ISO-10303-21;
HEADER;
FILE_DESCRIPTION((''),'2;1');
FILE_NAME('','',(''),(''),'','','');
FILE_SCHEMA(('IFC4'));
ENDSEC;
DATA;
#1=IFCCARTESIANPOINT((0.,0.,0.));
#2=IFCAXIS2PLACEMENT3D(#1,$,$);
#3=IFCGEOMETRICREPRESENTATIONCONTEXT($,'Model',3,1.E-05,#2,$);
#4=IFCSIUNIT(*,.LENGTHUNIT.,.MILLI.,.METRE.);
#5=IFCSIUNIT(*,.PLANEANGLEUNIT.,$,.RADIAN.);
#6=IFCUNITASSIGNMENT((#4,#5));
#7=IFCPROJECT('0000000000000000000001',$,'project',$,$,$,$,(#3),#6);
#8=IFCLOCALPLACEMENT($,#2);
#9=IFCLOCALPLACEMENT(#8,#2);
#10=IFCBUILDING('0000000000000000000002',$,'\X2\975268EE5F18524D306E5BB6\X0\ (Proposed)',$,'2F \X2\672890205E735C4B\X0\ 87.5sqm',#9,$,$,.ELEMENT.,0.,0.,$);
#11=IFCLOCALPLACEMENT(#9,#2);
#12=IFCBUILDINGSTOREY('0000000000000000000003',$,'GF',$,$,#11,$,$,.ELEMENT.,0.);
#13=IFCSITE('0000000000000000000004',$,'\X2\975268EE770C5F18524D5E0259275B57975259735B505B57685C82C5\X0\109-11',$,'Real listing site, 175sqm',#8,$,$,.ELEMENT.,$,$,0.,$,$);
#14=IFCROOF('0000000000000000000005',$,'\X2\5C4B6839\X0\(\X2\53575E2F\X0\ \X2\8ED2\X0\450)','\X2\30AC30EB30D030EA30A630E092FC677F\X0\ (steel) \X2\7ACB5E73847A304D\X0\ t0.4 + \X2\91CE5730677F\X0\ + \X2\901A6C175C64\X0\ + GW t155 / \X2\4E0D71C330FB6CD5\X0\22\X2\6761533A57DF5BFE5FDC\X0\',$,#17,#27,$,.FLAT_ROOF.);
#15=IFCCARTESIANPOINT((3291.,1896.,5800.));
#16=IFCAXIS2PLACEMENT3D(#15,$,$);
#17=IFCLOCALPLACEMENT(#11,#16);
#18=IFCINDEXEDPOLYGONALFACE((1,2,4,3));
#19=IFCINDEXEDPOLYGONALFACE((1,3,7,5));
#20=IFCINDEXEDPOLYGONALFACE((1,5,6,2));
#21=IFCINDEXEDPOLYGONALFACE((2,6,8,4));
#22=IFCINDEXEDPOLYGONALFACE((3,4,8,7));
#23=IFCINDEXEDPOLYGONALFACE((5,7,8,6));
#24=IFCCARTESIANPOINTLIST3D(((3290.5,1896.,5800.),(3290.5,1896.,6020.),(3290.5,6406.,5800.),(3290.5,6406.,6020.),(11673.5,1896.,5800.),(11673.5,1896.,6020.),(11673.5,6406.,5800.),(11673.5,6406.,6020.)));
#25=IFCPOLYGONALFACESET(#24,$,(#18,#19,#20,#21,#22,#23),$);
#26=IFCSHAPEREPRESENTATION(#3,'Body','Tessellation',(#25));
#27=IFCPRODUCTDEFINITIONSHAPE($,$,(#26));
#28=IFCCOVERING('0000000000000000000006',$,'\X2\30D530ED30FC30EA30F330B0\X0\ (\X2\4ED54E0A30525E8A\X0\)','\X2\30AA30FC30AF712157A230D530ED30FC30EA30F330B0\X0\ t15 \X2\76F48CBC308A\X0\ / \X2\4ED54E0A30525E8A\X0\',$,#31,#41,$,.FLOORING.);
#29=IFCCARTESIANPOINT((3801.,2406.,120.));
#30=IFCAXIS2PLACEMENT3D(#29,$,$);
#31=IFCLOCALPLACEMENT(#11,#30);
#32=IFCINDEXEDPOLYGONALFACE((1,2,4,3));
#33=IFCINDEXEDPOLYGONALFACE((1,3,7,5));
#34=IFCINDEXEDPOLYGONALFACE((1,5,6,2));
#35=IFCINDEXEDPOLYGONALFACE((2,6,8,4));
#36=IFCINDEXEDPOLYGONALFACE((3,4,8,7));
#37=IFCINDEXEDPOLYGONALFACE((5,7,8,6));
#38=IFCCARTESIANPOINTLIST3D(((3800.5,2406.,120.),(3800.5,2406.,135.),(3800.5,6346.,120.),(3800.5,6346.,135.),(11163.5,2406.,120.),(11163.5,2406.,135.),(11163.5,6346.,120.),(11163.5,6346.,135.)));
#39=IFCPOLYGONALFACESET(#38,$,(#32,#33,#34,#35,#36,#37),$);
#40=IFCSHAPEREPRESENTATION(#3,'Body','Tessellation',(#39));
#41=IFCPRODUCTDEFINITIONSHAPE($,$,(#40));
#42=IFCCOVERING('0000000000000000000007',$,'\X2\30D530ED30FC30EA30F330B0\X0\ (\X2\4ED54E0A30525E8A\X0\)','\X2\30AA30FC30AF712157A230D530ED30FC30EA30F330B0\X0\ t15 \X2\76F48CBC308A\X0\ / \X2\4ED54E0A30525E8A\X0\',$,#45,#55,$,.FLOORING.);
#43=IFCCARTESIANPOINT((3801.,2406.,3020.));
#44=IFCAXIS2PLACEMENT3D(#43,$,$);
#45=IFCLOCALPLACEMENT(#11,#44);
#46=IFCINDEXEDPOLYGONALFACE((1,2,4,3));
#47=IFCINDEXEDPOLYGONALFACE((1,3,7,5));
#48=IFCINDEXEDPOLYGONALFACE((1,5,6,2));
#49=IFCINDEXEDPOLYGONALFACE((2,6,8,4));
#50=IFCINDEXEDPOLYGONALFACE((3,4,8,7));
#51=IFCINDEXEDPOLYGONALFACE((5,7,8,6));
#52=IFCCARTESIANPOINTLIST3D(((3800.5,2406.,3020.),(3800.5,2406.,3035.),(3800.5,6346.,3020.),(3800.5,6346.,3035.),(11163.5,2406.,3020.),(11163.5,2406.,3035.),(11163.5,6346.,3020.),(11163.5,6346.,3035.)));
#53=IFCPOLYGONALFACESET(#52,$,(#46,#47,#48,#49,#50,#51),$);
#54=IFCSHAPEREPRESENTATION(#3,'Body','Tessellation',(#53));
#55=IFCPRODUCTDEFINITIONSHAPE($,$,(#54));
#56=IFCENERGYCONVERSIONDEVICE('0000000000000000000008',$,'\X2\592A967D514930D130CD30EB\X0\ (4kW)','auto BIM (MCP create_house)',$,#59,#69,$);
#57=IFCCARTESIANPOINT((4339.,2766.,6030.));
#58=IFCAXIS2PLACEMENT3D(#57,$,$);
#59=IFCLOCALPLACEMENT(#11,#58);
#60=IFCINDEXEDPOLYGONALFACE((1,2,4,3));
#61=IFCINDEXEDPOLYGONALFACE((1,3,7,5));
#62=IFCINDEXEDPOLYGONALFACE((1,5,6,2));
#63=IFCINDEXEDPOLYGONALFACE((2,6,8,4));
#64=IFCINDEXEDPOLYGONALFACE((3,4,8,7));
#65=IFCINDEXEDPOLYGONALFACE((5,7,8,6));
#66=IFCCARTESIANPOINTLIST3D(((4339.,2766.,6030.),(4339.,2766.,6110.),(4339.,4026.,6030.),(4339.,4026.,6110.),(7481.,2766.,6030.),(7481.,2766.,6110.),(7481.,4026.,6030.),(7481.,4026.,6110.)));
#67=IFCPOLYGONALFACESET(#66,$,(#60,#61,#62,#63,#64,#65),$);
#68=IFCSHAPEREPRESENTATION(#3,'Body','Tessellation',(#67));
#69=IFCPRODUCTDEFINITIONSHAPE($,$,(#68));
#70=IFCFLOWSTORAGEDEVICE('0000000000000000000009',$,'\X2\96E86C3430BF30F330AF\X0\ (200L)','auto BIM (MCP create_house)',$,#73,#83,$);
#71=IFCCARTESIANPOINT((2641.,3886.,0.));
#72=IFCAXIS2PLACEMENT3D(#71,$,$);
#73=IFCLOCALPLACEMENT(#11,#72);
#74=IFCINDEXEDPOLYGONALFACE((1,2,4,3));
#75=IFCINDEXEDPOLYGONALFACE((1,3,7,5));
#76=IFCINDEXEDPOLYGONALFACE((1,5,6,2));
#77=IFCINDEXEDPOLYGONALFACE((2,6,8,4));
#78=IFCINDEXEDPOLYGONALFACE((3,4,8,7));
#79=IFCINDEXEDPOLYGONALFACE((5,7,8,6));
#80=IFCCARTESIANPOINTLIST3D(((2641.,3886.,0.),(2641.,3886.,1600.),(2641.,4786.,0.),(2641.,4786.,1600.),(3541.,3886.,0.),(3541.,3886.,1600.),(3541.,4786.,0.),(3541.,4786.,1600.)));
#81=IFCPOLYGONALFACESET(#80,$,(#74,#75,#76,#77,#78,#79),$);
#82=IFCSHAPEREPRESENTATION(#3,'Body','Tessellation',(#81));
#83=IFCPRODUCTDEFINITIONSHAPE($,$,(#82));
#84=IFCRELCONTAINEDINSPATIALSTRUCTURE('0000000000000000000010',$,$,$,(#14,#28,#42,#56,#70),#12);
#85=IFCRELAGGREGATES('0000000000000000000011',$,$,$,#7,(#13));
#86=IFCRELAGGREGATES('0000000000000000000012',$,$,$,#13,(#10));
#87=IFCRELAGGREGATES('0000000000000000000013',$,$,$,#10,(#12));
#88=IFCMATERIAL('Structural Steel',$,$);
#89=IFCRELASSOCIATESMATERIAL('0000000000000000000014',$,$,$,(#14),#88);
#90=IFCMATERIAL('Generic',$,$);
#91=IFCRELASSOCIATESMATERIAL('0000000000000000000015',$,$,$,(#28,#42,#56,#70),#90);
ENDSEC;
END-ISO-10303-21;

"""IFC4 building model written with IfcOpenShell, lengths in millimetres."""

from ifc_helpers import new_model, si_unit, frame, frame_2d, origin, place, context, project, spatial, rectangle, extrude, material, element, save


model = new_model("IFC4")

# Units and contexts
model_context = context("Model", 3, precision=1e-05, world=origin())
ifc_project = project(units=[si_unit("LENGTHUNIT", "METRE", prefix="MILLI"), si_unit("PLANEANGLEUNIT", "RADIAN")], contexts=[model_context])

# Site, building, storey
site_placement = place(None, origin())
site = spatial("IfcSite", under=ifc_project, at=site_placement, Name="青森県弘前市大字青女子字桜苅109-11", ObjectType="Real listing site, 175sqm", CompositionType="ELEMENT", RefElevation=0.0)
building_placement = place(site_placement, origin())
building = spatial("IfcBuilding", under=site, at=building_placement, Name="青森弘前の家 (Proposed)", ObjectType="2F 木造平屋 87.5sqm", CompositionType="ELEMENT", ElevationOfRefHeight=0.0, ElevationOfTerrain=0.0)
storey_placement = place(building_placement, origin())
storey = spatial("IfcBuildingStorey", under=building, at=storey_placement, Name="GF", CompositionType="ELEMENT", Elevation=0.0)

# Roof
ifc_material_1 = material(Name="Structural Steel")
for number, where, name in (
    (1, (3291.0, 1896.0, 5800.0), "屋根(南帯 軒450)"),
):
    element("IfcRoof", number, at=place(storey_placement, frame(where)), inside=storey, material=ifc_material_1, Name=name, Description="ガルバリウム鋼板 (steel) 立平葺き t0.4 + 野地板 + 通気層 + GW t155 / 不燃・法22条区域対応", PredefinedType="FLAT_ROOF", context=model_context, shape_type="SweptSolid", body=[
        extrude(rectangle(XDim=8383.0, YDim=4510.0, at=frame_2d((4191.0, 2255.0))), frame((3291.0, 1896.0, 5800.0)), (0.0, 0.0, 1.0), 220.0),
    ])

# Coverings
ifc_material_2 = material(Name="Generic")
covering_1_placement = place(storey_placement, frame((3801.0, 2406.0, 120.0)))
element("IfcCovering", 2, at=covering_1_placement, inside=storey, material=ifc_material_2, Name="フローリング (仕上げ床)", Description="オーク無垢フローリング t15 直貼り / 仕上げ床", PredefinedType="FLOORING", context=model_context, shape_type="SweptSolid", body=[
    extrude(rectangle(XDim=7363.0, YDim=3940.0, at=frame_2d((3681.0, 1970.0))), frame((3801.0, 2406.0, 120.0)), (0.0, 0.0, 1.0), 15.0),
])
covering_2_placement = place(storey_placement, frame((3801.0, 2406.0, 3020.0)))
element("IfcCovering", 3, at=covering_2_placement, inside=storey, material=ifc_material_2, Name="フローリング (仕上げ床)", Description="オーク無垢フローリング t15 直貼り / 仕上げ床", PredefinedType="FLOORING", context=model_context, shape_type="SweptSolid", body=[
    extrude(rectangle(XDim=7363.0, YDim=3940.0, at=frame_2d((3681.0, 1970.0))), frame((3801.0, 2406.0, 3020.0)), (0.0, 0.0, 1.0), 15.0),
])

# Energy conversion device
energy_conversion_device_placement = place(storey_placement, frame((4339.0, 2766.0, 6030.0)))
element("IfcEnergyConversionDevice", 4, at=energy_conversion_device_placement, inside=storey, material=ifc_material_2, Name="太陽光パネル (4kW)", Description="auto BIM (MCP create_house)", context=model_context, shape_type="SweptSolid", body=[
    extrude(rectangle(XDim=3142.0, YDim=1260.0, at=frame_2d((1571.0, 630.0))), frame((4339.0, 2766.0, 6030.0)), (0.0, 0.0, 1.0), 80.0),
])

# Flow storage device
flow_storage_device_placement = place(storey_placement, frame((2641.0, 3886.0, 0.0)))
element("IfcFlowStorageDevice", 5, at=flow_storage_device_placement, inside=storey, material=ifc_material_2, Name="雨水タンク (200L)", Description="auto BIM (MCP create_house)", context=model_context, shape_type="SweptSolid", body=[
    extrude(rectangle(XDim=900.0, YDim=900.0, at=frame_2d((450.0, 450.0))), frame((2641.0, 3886.0, 0.0)), (0.0, 0.0, 1.0), 1600.0),
])

save(model, "model.ifc")
